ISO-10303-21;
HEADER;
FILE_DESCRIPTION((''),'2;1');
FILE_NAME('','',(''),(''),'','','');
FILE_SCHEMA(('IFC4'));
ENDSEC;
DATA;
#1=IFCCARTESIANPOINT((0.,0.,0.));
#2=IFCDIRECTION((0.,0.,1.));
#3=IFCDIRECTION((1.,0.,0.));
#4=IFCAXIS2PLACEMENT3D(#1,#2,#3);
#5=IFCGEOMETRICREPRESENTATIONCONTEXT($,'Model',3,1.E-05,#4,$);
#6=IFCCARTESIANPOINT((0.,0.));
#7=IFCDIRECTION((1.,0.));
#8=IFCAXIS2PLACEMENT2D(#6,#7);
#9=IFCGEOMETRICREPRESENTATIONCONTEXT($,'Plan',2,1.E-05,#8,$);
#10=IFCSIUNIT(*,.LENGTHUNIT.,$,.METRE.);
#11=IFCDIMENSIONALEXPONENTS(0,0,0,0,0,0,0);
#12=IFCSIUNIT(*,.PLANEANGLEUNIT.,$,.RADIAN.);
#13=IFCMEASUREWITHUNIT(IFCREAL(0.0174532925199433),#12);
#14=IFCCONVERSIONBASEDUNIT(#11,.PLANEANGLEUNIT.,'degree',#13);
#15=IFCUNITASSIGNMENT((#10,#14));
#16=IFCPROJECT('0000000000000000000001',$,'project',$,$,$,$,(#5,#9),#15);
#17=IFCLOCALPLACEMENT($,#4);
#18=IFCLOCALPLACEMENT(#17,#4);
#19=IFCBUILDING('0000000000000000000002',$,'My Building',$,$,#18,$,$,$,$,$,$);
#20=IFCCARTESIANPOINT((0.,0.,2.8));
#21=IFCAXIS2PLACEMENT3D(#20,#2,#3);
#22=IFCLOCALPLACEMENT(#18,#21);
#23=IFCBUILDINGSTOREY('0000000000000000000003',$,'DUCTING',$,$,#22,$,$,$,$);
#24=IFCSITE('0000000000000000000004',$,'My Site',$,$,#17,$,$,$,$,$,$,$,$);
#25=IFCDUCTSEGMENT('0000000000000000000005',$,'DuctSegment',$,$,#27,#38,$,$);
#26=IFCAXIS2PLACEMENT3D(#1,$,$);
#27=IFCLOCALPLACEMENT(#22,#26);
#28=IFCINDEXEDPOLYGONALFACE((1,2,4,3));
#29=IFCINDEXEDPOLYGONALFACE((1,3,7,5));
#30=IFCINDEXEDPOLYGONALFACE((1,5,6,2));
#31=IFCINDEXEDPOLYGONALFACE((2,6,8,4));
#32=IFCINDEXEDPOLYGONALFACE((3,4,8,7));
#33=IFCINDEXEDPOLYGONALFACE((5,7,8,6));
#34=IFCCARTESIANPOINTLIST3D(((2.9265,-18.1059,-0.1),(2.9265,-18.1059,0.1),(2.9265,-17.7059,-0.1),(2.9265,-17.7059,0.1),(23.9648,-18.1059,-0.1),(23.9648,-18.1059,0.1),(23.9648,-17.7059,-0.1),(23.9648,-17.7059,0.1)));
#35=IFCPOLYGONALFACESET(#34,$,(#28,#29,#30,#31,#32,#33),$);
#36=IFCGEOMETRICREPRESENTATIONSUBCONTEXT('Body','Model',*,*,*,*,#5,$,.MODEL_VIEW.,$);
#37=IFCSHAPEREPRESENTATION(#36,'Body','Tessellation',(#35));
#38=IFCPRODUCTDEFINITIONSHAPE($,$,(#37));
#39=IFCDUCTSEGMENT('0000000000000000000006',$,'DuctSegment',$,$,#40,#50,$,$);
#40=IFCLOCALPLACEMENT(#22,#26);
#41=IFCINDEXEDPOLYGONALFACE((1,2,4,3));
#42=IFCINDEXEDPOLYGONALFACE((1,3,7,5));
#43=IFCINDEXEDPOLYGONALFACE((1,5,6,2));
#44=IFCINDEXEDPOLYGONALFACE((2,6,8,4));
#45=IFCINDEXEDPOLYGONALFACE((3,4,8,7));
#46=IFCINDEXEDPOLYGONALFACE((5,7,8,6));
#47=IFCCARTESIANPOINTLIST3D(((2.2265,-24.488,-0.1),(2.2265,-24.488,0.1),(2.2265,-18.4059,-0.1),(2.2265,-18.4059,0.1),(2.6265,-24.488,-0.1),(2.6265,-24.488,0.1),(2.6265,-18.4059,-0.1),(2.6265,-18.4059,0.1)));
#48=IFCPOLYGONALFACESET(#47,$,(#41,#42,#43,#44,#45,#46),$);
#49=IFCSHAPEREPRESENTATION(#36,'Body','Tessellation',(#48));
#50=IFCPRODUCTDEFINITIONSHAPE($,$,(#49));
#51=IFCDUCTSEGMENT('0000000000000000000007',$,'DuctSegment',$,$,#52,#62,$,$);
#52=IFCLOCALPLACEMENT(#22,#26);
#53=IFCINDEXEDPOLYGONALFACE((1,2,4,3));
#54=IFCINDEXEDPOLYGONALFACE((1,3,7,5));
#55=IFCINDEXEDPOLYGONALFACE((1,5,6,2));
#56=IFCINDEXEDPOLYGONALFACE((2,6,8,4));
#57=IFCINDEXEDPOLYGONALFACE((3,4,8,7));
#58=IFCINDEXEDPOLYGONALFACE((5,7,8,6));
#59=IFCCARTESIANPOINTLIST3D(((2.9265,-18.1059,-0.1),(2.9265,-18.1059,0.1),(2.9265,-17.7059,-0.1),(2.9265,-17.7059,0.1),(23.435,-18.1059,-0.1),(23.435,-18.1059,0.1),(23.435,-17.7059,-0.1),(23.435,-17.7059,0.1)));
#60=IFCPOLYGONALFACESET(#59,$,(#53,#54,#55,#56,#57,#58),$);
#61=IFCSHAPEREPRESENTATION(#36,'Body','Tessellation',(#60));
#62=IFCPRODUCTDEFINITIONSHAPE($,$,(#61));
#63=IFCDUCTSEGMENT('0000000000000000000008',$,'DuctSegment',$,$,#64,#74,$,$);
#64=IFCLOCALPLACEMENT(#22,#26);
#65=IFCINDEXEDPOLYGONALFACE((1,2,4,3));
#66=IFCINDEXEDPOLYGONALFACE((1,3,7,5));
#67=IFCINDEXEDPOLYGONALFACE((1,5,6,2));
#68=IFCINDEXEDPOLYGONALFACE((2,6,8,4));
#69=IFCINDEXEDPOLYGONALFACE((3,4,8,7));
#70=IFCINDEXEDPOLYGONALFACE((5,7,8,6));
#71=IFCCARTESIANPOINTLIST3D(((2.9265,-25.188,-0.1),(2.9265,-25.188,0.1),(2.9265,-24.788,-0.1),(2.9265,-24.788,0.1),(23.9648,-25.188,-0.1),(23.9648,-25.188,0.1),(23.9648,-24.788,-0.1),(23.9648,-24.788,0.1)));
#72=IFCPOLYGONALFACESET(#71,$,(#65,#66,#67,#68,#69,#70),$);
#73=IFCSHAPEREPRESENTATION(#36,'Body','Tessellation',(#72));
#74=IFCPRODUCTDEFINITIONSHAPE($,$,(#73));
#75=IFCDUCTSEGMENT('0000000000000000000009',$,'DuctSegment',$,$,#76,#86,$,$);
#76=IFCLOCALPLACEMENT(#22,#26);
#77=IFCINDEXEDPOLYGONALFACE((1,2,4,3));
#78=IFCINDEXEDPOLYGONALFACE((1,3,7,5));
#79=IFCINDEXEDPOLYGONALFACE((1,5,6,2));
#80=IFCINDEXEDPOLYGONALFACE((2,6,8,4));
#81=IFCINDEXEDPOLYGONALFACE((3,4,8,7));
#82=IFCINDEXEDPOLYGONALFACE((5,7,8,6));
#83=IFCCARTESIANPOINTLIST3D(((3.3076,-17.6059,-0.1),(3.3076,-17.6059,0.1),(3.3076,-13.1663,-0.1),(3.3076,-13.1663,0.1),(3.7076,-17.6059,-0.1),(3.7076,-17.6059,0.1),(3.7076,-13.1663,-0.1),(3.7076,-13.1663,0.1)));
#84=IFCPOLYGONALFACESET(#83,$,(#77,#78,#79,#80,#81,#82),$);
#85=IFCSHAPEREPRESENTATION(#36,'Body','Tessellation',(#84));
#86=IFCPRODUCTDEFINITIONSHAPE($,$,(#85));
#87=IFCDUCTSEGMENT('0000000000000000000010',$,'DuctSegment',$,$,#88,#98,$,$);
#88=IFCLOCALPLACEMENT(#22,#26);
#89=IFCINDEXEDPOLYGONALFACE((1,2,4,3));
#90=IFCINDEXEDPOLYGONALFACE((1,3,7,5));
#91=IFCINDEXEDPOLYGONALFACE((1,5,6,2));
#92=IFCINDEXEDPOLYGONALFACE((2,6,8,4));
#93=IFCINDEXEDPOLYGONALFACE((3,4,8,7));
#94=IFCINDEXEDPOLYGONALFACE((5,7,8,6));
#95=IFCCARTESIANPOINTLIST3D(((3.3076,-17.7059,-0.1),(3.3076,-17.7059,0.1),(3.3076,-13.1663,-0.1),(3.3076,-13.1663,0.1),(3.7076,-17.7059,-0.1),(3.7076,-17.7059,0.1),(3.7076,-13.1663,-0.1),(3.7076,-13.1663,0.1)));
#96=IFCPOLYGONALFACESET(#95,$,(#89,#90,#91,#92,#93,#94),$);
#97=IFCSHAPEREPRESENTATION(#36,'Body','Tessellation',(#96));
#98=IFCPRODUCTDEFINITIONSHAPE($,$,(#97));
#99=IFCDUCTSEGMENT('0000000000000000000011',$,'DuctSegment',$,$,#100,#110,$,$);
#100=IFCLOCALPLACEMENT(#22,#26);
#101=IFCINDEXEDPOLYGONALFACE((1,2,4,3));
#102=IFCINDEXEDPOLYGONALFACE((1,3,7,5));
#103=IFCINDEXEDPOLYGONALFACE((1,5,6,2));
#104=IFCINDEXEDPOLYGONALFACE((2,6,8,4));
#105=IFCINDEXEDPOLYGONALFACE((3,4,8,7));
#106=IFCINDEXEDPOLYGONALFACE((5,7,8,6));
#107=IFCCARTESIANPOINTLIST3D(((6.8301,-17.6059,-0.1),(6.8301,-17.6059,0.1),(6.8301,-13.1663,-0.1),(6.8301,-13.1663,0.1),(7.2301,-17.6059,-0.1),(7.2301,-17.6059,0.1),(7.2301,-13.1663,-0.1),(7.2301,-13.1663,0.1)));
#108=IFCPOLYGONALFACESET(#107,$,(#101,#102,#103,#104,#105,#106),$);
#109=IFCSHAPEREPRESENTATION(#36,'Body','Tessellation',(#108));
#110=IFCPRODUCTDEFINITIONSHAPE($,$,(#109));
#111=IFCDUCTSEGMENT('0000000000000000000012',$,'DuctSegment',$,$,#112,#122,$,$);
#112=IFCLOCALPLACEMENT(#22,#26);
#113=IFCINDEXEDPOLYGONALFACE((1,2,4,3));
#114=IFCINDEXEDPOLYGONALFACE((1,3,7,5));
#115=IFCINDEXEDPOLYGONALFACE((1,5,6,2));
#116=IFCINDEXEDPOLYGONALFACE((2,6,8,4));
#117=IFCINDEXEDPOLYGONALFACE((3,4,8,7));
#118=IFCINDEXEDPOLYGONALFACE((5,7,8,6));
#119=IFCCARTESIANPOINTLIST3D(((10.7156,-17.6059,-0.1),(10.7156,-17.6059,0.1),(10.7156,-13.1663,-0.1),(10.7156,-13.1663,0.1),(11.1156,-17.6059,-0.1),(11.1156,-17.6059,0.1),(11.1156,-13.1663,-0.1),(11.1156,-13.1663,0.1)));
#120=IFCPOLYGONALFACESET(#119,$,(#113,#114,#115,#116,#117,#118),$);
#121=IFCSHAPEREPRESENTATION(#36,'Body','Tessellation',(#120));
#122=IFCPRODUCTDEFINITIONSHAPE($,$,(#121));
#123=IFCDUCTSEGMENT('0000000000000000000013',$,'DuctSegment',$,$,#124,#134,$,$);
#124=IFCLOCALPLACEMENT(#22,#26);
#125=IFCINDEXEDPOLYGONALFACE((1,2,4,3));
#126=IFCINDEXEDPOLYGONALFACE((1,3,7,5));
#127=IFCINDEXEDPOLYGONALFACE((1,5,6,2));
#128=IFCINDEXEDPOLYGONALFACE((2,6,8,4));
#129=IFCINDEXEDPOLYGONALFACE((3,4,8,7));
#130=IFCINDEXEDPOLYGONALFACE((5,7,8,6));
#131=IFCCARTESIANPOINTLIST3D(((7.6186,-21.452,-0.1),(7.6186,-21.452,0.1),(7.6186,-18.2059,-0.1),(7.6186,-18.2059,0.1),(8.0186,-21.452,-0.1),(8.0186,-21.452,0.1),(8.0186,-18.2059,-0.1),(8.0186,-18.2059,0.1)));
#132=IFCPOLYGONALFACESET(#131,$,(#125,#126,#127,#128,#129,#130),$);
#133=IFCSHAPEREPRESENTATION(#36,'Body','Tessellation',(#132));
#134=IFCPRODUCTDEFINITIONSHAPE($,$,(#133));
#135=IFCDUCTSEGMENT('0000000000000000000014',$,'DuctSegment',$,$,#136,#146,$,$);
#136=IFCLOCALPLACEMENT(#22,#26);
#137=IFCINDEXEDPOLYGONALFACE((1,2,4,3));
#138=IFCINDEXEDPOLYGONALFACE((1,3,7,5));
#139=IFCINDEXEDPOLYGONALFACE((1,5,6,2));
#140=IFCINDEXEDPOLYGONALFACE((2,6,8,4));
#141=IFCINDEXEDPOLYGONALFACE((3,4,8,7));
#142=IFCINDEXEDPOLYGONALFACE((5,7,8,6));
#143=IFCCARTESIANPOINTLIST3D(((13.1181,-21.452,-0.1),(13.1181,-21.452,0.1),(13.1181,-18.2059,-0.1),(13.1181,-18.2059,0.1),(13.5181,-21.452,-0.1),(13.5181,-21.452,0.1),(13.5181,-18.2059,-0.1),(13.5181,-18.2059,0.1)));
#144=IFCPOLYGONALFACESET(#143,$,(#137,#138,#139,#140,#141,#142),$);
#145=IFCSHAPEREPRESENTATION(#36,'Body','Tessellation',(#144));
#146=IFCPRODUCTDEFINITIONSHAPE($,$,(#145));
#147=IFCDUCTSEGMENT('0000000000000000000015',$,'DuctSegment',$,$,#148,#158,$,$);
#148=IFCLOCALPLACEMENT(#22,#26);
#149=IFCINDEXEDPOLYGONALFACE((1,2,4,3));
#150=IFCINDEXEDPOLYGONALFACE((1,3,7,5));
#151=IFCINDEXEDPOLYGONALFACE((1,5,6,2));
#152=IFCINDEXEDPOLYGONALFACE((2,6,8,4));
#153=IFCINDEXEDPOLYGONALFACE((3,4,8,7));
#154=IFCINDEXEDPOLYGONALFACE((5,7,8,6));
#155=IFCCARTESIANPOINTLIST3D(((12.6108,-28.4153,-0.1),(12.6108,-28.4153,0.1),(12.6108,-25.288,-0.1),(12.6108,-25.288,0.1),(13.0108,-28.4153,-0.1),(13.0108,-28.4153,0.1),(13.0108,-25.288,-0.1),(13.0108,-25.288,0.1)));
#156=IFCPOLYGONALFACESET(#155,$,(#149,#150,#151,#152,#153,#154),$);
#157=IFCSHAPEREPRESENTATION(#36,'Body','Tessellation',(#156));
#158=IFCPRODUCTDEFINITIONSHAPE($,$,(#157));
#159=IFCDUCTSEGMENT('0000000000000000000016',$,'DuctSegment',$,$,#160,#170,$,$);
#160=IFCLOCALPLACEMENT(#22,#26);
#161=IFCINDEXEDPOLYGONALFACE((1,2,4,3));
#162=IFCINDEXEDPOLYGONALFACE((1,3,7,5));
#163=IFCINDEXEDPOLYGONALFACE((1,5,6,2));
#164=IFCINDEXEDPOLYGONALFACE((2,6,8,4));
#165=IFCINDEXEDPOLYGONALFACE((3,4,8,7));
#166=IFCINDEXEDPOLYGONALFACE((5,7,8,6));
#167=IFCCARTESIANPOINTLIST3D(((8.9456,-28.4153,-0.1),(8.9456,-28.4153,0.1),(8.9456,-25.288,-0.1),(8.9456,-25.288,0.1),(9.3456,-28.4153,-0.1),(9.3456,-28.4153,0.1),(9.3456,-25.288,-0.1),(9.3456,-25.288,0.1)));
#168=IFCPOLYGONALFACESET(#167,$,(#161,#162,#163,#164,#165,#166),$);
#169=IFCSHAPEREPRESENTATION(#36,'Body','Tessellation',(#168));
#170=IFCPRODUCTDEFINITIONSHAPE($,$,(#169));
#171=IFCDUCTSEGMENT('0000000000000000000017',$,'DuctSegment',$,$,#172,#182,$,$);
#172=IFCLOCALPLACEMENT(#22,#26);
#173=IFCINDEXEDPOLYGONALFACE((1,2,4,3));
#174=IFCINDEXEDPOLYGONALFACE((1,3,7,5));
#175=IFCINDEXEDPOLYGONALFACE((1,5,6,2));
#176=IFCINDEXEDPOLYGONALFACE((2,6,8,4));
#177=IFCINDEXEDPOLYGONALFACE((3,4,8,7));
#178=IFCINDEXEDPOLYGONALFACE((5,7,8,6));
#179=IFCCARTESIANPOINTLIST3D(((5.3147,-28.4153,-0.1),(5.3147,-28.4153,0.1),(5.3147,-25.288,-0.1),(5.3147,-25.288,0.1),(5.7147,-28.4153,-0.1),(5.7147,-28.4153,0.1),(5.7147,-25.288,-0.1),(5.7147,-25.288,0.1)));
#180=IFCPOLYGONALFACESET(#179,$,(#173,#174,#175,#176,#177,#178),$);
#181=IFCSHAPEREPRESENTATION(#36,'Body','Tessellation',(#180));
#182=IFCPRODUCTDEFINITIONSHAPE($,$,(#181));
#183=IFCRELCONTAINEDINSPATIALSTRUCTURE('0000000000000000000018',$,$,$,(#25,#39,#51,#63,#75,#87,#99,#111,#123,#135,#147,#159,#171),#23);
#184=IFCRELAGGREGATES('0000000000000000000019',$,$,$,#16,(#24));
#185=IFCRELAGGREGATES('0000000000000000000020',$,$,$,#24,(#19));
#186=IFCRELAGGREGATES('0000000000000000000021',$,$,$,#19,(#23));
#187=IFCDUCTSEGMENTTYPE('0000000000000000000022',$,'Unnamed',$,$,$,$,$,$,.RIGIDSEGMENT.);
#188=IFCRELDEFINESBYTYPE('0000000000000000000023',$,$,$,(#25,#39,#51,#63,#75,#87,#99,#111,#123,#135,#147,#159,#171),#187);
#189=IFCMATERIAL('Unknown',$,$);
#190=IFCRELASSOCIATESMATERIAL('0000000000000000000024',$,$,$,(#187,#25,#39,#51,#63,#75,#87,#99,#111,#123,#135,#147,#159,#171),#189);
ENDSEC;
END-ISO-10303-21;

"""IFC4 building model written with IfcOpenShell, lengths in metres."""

from ifc_helpers import new_model, entity, si_unit, converted_unit, frame, origin_with_axes, origin_2d_with_axis, place, context, subcontext, project, spatial, rectangle, extrude, material, material_profile, profile_set, profile_usage, type_object, element, save


model = new_model("IFC4")

# Units and contexts
model_context = context("Model", 3, precision=1e-05, world=origin_with_axes())
plan_context = context("Plan", 2, precision=1e-05, world=origin_2d_with_axis())
body_context = subcontext(model_context, "Body", "Model", "MODEL_VIEW")
ifc_project = project(units=[si_unit("LENGTHUNIT", "METRE"), converted_unit("PLANEANGLEUNIT", "degree", entity("IfcReal", 0.0174532925199433), si_unit("PLANEANGLEUNIT", "RADIAN"), dimensions=[0, 0, 0, 0, 0, 0, 0])], contexts=[model_context, plan_context])

# Site, building, storey
site_placement = place(None, origin_with_axes())
site = spatial("IfcSite", under=ifc_project, at=site_placement, Name="My Site")
building_placement = place(site_placement, origin_with_axes())
building = spatial("IfcBuilding", under=site, at=building_placement, Name="My Building")
storey_placement = place(building_placement, frame((0.0, 0.0, 2.8), z_axis=(0.0, 0.0, 1.0), x_axis=(1.0, 0.0, 0.0)))
storey = spatial("IfcBuildingStorey", under=building, at=storey_placement, Name="DUCTING")

# Duct segments
ifc_material = material(Name="Unknown")
ifc_material_profile_1 = material_profile(ifc_material, rectangle(XDim=0.4, YDim=0.2))
ifc_profile_set_1 = profile_set([ifc_material_profile_1])
ifc_profile_usage_1 = profile_usage(ifc_profile_set_1, cardinal=5)
duct_segment_type = type_object("IfcDuctSegmentType", Name="Unnamed", PredefinedType="RIGIDSEGMENT", material=ifc_profile_set_1)
duct_segment_1_placement = place(storey_placement, frame((2.9265, -17.9059, 0.0), z_axis=(1.0, 0.0, 0.0), x_axis=(0.0, 1.0, 0.0)))
element("IfcDuctSegment", 1, at=duct_segment_1_placement, inside=storey, type_object=duct_segment_type, material=ifc_profile_usage_1, Name="DuctSegment", context=body_context, shape_type="SweptSolid", body=[
    extrude(rectangle(XDim=0.4, YDim=0.2), origin_with_axes(), (0.0, 0.0, 1.0), 21.0383),
])
ifc_profile_usage_2 = profile_usage(ifc_profile_set_1, cardinal=5)
duct_segment_2_placement = place(storey_placement, frame((2.4265, -18.4059, 0.0), z_axis=(0.0, -1.0, 0.0), x_axis=(-1.0, 0.0, 0.0)))
element("IfcDuctSegment", 2, at=duct_segment_2_placement, inside=storey, type_object=duct_segment_type, material=ifc_profile_usage_2, Name="DuctSegment", context=body_context, shape_type="SweptSolid", body=[
    extrude(rectangle(XDim=0.4, YDim=0.2), origin_with_axes(), (0.0, 0.0, 1.0), 6.0821),
])
ifc_profile_usage_3 = profile_usage(ifc_profile_set_1, cardinal=5)
duct_segment_3_placement = place(storey_placement, frame((2.9265, -17.9059, 0.0), z_axis=(1.0, 0.0, 0.0), x_axis=(0.0, 1.0, 0.0)))
element("IfcDuctSegment", 3, at=duct_segment_3_placement, inside=storey, type_object=duct_segment_type, material=ifc_profile_usage_3, Name="DuctSegment", context=body_context, shape_type="SweptSolid", body=[
    extrude(rectangle(XDim=0.4, YDim=0.2), origin_with_axes(), (0.0, 0.0, 1.0), 20.5085),
])
ifc_profile_usage_4 = profile_usage(ifc_profile_set_1, cardinal=5)
duct_segment_4_placement = place(storey_placement, frame((2.9265, -24.988, 0.0), z_axis=(1.0, 0.0, 0.0), x_axis=(0.0, 1.0, 0.0)))
element("IfcDuctSegment", 4, at=duct_segment_4_placement, inside=storey, type_object=duct_segment_type, material=ifc_profile_usage_4, Name="DuctSegment", context=body_context, shape_type="SweptSolid", body=[
    extrude(rectangle(XDim=0.4, YDim=0.2), origin_with_axes(), (0.0, 0.0, 1.0), 21.0383),
])
ifc_profile_usage_5 = profile_usage(ifc_profile_set_1, cardinal=5)
duct_segment_5_placement = place(storey_placement, frame((3.5076, -13.1663, 0.0), z_axis=(0.0, -1.0, 0.0), x_axis=(-1.0, 0.0, 0.0)))
element("IfcDuctSegment", 5, at=duct_segment_5_placement, inside=storey, type_object=duct_segment_type, material=ifc_profile_usage_5, Name="DuctSegment", context=body_context, shape_type="SweptSolid", body=[
    extrude(rectangle(XDim=0.4, YDim=0.2), origin_with_axes(), (0.0, 0.0, 1.0), 4.4396),
])
ifc_profile_usage_6 = profile_usage(ifc_profile_set_1, cardinal=5)
duct_segment_6_placement = place(storey_placement, frame((3.5076, -13.1663, 0.0), z_axis=(0.0, -1.0, 0.0), x_axis=(-1.0, 0.0, 0.0)))
element("IfcDuctSegment", 6, at=duct_segment_6_placement, inside=storey, type_object=duct_segment_type, material=ifc_profile_usage_6, Name="DuctSegment", context=body_context, shape_type="SweptSolid", body=[
    extrude(rectangle(XDim=0.4, YDim=0.2), origin_with_axes(), (0.0, 0.0, 1.0), 4.5396),
])
ifc_profile_usage_7 = profile_usage(ifc_profile_set_1, cardinal=5)
duct_segment_7_placement = place(storey_placement, frame((7.0301, -13.1663, 0.0), z_axis=(0.0, -1.0, 0.0), x_axis=(-1.0, 0.0, 0.0)))
element("IfcDuctSegment", 7, at=duct_segment_7_placement, inside=storey, type_object=duct_segment_type, material=ifc_profile_usage_7, Name="DuctSegment", context=body_context, shape_type="SweptSolid", body=[
    extrude(rectangle(XDim=0.4, YDim=0.2), origin_with_axes(), (0.0, 0.0, 1.0), 4.4396),
])
ifc_profile_usage_8 = profile_usage(ifc_profile_set_1, cardinal=5)
duct_segment_8_placement = place(storey_placement, frame((10.9156, -13.1663, 0.0), z_axis=(0.0, -1.0, 0.0), x_axis=(-1.0, 0.0, 0.0)))
element("IfcDuctSegment", 8, at=duct_segment_8_placement, inside=storey, type_object=duct_segment_type, material=ifc_profile_usage_8, Name="DuctSegment", context=body_context, shape_type="SweptSolid", body=[
    extrude(rectangle(XDim=0.4, YDim=0.2), origin_with_axes(), (0.0, 0.0, 1.0), 4.4396),
])
ifc_profile_usage_9 = profile_usage(ifc_profile_set_1, cardinal=5)
duct_segment_9_placement = place(storey_placement, frame((7.8186, -21.452, 0.0), z_axis=(0.0, 1.0, 0.0), x_axis=(1.0, 0.0, 0.0)))
element("IfcDuctSegment", 9, at=duct_segment_9_placement, inside=storey, type_object=duct_segment_type, material=ifc_profile_usage_9, Name="DuctSegment", context=body_context, shape_type="SweptSolid", body=[
    extrude(rectangle(XDim=0.4, YDim=0.2), origin_with_axes(), (0.0, 0.0, 1.0), 3.2461),
])
ifc_profile_usage_10 = profile_usage(ifc_profile_set_1, cardinal=5)
duct_segment_10_placement = place(storey_placement, frame((13.3181, -21.452, 0.0), z_axis=(0.0, 1.0, 0.0), x_axis=(1.0, 0.0, 0.0)))
element("IfcDuctSegment", 10, at=duct_segment_10_placement, inside=storey, type_object=duct_segment_type, material=ifc_profile_usage_10, Name="DuctSegment", context=body_context, shape_type="SweptSolid", body=[
    extrude(rectangle(XDim=0.4, YDim=0.2), origin_with_axes(), (0.0, 0.0, 1.0), 3.2461),
])
ifc_profile_usage_11 = profile_usage(ifc_profile_set_1, cardinal=5)
duct_segment_11_placement = place(storey_placement, frame((12.8108, -28.4153, 0.0), z_axis=(0.0, 1.0, 0.0), x_axis=(1.0, 0.0, 0.0)))
element("IfcDuctSegment", 11, at=duct_segment_11_placement, inside=storey, type_object=duct_segment_type, material=ifc_profile_usage_11, Name="DuctSegment", context=body_context, shape_type="SweptSolid", body=[
    extrude(rectangle(XDim=0.4, YDim=0.2), origin_with_axes(), (0.0, 0.0, 1.0), 3.1273),
])
ifc_profile_usage_12 = profile_usage(ifc_profile_set_1, cardinal=5)
duct_segment_12_placement = place(storey_placement, frame((9.1456, -28.4153, 0.0), z_axis=(0.0, 1.0, 0.0), x_axis=(1.0, 0.0, 0.0)))
element("IfcDuctSegment", 12, at=duct_segment_12_placement, inside=storey, type_object=duct_segment_type, material=ifc_profile_usage_12, Name="DuctSegment", context=body_context, shape_type="SweptSolid", body=[
    extrude(rectangle(XDim=0.4, YDim=0.2), origin_with_axes(), (0.0, 0.0, 1.0), 3.1273),
])
ifc_profile_usage_13 = profile_usage(ifc_profile_set_1, cardinal=5)
duct_segment_13_placement = place(storey_placement, frame((5.5147, -28.4153, 0.0), z_axis=(0.0, 1.0, 0.0), x_axis=(1.0, 0.0, 0.0)))
element("IfcDuctSegment", 13, at=duct_segment_13_placement, inside=storey, type_object=duct_segment_type, material=ifc_profile_usage_13, Name="DuctSegment", context=body_context, shape_type="SweptSolid", body=[
    extrude(rectangle(XDim=0.4, YDim=0.2), origin_with_axes(), (0.0, 0.0, 1.0), 3.1273),
])

save(model, "model.ifc")
